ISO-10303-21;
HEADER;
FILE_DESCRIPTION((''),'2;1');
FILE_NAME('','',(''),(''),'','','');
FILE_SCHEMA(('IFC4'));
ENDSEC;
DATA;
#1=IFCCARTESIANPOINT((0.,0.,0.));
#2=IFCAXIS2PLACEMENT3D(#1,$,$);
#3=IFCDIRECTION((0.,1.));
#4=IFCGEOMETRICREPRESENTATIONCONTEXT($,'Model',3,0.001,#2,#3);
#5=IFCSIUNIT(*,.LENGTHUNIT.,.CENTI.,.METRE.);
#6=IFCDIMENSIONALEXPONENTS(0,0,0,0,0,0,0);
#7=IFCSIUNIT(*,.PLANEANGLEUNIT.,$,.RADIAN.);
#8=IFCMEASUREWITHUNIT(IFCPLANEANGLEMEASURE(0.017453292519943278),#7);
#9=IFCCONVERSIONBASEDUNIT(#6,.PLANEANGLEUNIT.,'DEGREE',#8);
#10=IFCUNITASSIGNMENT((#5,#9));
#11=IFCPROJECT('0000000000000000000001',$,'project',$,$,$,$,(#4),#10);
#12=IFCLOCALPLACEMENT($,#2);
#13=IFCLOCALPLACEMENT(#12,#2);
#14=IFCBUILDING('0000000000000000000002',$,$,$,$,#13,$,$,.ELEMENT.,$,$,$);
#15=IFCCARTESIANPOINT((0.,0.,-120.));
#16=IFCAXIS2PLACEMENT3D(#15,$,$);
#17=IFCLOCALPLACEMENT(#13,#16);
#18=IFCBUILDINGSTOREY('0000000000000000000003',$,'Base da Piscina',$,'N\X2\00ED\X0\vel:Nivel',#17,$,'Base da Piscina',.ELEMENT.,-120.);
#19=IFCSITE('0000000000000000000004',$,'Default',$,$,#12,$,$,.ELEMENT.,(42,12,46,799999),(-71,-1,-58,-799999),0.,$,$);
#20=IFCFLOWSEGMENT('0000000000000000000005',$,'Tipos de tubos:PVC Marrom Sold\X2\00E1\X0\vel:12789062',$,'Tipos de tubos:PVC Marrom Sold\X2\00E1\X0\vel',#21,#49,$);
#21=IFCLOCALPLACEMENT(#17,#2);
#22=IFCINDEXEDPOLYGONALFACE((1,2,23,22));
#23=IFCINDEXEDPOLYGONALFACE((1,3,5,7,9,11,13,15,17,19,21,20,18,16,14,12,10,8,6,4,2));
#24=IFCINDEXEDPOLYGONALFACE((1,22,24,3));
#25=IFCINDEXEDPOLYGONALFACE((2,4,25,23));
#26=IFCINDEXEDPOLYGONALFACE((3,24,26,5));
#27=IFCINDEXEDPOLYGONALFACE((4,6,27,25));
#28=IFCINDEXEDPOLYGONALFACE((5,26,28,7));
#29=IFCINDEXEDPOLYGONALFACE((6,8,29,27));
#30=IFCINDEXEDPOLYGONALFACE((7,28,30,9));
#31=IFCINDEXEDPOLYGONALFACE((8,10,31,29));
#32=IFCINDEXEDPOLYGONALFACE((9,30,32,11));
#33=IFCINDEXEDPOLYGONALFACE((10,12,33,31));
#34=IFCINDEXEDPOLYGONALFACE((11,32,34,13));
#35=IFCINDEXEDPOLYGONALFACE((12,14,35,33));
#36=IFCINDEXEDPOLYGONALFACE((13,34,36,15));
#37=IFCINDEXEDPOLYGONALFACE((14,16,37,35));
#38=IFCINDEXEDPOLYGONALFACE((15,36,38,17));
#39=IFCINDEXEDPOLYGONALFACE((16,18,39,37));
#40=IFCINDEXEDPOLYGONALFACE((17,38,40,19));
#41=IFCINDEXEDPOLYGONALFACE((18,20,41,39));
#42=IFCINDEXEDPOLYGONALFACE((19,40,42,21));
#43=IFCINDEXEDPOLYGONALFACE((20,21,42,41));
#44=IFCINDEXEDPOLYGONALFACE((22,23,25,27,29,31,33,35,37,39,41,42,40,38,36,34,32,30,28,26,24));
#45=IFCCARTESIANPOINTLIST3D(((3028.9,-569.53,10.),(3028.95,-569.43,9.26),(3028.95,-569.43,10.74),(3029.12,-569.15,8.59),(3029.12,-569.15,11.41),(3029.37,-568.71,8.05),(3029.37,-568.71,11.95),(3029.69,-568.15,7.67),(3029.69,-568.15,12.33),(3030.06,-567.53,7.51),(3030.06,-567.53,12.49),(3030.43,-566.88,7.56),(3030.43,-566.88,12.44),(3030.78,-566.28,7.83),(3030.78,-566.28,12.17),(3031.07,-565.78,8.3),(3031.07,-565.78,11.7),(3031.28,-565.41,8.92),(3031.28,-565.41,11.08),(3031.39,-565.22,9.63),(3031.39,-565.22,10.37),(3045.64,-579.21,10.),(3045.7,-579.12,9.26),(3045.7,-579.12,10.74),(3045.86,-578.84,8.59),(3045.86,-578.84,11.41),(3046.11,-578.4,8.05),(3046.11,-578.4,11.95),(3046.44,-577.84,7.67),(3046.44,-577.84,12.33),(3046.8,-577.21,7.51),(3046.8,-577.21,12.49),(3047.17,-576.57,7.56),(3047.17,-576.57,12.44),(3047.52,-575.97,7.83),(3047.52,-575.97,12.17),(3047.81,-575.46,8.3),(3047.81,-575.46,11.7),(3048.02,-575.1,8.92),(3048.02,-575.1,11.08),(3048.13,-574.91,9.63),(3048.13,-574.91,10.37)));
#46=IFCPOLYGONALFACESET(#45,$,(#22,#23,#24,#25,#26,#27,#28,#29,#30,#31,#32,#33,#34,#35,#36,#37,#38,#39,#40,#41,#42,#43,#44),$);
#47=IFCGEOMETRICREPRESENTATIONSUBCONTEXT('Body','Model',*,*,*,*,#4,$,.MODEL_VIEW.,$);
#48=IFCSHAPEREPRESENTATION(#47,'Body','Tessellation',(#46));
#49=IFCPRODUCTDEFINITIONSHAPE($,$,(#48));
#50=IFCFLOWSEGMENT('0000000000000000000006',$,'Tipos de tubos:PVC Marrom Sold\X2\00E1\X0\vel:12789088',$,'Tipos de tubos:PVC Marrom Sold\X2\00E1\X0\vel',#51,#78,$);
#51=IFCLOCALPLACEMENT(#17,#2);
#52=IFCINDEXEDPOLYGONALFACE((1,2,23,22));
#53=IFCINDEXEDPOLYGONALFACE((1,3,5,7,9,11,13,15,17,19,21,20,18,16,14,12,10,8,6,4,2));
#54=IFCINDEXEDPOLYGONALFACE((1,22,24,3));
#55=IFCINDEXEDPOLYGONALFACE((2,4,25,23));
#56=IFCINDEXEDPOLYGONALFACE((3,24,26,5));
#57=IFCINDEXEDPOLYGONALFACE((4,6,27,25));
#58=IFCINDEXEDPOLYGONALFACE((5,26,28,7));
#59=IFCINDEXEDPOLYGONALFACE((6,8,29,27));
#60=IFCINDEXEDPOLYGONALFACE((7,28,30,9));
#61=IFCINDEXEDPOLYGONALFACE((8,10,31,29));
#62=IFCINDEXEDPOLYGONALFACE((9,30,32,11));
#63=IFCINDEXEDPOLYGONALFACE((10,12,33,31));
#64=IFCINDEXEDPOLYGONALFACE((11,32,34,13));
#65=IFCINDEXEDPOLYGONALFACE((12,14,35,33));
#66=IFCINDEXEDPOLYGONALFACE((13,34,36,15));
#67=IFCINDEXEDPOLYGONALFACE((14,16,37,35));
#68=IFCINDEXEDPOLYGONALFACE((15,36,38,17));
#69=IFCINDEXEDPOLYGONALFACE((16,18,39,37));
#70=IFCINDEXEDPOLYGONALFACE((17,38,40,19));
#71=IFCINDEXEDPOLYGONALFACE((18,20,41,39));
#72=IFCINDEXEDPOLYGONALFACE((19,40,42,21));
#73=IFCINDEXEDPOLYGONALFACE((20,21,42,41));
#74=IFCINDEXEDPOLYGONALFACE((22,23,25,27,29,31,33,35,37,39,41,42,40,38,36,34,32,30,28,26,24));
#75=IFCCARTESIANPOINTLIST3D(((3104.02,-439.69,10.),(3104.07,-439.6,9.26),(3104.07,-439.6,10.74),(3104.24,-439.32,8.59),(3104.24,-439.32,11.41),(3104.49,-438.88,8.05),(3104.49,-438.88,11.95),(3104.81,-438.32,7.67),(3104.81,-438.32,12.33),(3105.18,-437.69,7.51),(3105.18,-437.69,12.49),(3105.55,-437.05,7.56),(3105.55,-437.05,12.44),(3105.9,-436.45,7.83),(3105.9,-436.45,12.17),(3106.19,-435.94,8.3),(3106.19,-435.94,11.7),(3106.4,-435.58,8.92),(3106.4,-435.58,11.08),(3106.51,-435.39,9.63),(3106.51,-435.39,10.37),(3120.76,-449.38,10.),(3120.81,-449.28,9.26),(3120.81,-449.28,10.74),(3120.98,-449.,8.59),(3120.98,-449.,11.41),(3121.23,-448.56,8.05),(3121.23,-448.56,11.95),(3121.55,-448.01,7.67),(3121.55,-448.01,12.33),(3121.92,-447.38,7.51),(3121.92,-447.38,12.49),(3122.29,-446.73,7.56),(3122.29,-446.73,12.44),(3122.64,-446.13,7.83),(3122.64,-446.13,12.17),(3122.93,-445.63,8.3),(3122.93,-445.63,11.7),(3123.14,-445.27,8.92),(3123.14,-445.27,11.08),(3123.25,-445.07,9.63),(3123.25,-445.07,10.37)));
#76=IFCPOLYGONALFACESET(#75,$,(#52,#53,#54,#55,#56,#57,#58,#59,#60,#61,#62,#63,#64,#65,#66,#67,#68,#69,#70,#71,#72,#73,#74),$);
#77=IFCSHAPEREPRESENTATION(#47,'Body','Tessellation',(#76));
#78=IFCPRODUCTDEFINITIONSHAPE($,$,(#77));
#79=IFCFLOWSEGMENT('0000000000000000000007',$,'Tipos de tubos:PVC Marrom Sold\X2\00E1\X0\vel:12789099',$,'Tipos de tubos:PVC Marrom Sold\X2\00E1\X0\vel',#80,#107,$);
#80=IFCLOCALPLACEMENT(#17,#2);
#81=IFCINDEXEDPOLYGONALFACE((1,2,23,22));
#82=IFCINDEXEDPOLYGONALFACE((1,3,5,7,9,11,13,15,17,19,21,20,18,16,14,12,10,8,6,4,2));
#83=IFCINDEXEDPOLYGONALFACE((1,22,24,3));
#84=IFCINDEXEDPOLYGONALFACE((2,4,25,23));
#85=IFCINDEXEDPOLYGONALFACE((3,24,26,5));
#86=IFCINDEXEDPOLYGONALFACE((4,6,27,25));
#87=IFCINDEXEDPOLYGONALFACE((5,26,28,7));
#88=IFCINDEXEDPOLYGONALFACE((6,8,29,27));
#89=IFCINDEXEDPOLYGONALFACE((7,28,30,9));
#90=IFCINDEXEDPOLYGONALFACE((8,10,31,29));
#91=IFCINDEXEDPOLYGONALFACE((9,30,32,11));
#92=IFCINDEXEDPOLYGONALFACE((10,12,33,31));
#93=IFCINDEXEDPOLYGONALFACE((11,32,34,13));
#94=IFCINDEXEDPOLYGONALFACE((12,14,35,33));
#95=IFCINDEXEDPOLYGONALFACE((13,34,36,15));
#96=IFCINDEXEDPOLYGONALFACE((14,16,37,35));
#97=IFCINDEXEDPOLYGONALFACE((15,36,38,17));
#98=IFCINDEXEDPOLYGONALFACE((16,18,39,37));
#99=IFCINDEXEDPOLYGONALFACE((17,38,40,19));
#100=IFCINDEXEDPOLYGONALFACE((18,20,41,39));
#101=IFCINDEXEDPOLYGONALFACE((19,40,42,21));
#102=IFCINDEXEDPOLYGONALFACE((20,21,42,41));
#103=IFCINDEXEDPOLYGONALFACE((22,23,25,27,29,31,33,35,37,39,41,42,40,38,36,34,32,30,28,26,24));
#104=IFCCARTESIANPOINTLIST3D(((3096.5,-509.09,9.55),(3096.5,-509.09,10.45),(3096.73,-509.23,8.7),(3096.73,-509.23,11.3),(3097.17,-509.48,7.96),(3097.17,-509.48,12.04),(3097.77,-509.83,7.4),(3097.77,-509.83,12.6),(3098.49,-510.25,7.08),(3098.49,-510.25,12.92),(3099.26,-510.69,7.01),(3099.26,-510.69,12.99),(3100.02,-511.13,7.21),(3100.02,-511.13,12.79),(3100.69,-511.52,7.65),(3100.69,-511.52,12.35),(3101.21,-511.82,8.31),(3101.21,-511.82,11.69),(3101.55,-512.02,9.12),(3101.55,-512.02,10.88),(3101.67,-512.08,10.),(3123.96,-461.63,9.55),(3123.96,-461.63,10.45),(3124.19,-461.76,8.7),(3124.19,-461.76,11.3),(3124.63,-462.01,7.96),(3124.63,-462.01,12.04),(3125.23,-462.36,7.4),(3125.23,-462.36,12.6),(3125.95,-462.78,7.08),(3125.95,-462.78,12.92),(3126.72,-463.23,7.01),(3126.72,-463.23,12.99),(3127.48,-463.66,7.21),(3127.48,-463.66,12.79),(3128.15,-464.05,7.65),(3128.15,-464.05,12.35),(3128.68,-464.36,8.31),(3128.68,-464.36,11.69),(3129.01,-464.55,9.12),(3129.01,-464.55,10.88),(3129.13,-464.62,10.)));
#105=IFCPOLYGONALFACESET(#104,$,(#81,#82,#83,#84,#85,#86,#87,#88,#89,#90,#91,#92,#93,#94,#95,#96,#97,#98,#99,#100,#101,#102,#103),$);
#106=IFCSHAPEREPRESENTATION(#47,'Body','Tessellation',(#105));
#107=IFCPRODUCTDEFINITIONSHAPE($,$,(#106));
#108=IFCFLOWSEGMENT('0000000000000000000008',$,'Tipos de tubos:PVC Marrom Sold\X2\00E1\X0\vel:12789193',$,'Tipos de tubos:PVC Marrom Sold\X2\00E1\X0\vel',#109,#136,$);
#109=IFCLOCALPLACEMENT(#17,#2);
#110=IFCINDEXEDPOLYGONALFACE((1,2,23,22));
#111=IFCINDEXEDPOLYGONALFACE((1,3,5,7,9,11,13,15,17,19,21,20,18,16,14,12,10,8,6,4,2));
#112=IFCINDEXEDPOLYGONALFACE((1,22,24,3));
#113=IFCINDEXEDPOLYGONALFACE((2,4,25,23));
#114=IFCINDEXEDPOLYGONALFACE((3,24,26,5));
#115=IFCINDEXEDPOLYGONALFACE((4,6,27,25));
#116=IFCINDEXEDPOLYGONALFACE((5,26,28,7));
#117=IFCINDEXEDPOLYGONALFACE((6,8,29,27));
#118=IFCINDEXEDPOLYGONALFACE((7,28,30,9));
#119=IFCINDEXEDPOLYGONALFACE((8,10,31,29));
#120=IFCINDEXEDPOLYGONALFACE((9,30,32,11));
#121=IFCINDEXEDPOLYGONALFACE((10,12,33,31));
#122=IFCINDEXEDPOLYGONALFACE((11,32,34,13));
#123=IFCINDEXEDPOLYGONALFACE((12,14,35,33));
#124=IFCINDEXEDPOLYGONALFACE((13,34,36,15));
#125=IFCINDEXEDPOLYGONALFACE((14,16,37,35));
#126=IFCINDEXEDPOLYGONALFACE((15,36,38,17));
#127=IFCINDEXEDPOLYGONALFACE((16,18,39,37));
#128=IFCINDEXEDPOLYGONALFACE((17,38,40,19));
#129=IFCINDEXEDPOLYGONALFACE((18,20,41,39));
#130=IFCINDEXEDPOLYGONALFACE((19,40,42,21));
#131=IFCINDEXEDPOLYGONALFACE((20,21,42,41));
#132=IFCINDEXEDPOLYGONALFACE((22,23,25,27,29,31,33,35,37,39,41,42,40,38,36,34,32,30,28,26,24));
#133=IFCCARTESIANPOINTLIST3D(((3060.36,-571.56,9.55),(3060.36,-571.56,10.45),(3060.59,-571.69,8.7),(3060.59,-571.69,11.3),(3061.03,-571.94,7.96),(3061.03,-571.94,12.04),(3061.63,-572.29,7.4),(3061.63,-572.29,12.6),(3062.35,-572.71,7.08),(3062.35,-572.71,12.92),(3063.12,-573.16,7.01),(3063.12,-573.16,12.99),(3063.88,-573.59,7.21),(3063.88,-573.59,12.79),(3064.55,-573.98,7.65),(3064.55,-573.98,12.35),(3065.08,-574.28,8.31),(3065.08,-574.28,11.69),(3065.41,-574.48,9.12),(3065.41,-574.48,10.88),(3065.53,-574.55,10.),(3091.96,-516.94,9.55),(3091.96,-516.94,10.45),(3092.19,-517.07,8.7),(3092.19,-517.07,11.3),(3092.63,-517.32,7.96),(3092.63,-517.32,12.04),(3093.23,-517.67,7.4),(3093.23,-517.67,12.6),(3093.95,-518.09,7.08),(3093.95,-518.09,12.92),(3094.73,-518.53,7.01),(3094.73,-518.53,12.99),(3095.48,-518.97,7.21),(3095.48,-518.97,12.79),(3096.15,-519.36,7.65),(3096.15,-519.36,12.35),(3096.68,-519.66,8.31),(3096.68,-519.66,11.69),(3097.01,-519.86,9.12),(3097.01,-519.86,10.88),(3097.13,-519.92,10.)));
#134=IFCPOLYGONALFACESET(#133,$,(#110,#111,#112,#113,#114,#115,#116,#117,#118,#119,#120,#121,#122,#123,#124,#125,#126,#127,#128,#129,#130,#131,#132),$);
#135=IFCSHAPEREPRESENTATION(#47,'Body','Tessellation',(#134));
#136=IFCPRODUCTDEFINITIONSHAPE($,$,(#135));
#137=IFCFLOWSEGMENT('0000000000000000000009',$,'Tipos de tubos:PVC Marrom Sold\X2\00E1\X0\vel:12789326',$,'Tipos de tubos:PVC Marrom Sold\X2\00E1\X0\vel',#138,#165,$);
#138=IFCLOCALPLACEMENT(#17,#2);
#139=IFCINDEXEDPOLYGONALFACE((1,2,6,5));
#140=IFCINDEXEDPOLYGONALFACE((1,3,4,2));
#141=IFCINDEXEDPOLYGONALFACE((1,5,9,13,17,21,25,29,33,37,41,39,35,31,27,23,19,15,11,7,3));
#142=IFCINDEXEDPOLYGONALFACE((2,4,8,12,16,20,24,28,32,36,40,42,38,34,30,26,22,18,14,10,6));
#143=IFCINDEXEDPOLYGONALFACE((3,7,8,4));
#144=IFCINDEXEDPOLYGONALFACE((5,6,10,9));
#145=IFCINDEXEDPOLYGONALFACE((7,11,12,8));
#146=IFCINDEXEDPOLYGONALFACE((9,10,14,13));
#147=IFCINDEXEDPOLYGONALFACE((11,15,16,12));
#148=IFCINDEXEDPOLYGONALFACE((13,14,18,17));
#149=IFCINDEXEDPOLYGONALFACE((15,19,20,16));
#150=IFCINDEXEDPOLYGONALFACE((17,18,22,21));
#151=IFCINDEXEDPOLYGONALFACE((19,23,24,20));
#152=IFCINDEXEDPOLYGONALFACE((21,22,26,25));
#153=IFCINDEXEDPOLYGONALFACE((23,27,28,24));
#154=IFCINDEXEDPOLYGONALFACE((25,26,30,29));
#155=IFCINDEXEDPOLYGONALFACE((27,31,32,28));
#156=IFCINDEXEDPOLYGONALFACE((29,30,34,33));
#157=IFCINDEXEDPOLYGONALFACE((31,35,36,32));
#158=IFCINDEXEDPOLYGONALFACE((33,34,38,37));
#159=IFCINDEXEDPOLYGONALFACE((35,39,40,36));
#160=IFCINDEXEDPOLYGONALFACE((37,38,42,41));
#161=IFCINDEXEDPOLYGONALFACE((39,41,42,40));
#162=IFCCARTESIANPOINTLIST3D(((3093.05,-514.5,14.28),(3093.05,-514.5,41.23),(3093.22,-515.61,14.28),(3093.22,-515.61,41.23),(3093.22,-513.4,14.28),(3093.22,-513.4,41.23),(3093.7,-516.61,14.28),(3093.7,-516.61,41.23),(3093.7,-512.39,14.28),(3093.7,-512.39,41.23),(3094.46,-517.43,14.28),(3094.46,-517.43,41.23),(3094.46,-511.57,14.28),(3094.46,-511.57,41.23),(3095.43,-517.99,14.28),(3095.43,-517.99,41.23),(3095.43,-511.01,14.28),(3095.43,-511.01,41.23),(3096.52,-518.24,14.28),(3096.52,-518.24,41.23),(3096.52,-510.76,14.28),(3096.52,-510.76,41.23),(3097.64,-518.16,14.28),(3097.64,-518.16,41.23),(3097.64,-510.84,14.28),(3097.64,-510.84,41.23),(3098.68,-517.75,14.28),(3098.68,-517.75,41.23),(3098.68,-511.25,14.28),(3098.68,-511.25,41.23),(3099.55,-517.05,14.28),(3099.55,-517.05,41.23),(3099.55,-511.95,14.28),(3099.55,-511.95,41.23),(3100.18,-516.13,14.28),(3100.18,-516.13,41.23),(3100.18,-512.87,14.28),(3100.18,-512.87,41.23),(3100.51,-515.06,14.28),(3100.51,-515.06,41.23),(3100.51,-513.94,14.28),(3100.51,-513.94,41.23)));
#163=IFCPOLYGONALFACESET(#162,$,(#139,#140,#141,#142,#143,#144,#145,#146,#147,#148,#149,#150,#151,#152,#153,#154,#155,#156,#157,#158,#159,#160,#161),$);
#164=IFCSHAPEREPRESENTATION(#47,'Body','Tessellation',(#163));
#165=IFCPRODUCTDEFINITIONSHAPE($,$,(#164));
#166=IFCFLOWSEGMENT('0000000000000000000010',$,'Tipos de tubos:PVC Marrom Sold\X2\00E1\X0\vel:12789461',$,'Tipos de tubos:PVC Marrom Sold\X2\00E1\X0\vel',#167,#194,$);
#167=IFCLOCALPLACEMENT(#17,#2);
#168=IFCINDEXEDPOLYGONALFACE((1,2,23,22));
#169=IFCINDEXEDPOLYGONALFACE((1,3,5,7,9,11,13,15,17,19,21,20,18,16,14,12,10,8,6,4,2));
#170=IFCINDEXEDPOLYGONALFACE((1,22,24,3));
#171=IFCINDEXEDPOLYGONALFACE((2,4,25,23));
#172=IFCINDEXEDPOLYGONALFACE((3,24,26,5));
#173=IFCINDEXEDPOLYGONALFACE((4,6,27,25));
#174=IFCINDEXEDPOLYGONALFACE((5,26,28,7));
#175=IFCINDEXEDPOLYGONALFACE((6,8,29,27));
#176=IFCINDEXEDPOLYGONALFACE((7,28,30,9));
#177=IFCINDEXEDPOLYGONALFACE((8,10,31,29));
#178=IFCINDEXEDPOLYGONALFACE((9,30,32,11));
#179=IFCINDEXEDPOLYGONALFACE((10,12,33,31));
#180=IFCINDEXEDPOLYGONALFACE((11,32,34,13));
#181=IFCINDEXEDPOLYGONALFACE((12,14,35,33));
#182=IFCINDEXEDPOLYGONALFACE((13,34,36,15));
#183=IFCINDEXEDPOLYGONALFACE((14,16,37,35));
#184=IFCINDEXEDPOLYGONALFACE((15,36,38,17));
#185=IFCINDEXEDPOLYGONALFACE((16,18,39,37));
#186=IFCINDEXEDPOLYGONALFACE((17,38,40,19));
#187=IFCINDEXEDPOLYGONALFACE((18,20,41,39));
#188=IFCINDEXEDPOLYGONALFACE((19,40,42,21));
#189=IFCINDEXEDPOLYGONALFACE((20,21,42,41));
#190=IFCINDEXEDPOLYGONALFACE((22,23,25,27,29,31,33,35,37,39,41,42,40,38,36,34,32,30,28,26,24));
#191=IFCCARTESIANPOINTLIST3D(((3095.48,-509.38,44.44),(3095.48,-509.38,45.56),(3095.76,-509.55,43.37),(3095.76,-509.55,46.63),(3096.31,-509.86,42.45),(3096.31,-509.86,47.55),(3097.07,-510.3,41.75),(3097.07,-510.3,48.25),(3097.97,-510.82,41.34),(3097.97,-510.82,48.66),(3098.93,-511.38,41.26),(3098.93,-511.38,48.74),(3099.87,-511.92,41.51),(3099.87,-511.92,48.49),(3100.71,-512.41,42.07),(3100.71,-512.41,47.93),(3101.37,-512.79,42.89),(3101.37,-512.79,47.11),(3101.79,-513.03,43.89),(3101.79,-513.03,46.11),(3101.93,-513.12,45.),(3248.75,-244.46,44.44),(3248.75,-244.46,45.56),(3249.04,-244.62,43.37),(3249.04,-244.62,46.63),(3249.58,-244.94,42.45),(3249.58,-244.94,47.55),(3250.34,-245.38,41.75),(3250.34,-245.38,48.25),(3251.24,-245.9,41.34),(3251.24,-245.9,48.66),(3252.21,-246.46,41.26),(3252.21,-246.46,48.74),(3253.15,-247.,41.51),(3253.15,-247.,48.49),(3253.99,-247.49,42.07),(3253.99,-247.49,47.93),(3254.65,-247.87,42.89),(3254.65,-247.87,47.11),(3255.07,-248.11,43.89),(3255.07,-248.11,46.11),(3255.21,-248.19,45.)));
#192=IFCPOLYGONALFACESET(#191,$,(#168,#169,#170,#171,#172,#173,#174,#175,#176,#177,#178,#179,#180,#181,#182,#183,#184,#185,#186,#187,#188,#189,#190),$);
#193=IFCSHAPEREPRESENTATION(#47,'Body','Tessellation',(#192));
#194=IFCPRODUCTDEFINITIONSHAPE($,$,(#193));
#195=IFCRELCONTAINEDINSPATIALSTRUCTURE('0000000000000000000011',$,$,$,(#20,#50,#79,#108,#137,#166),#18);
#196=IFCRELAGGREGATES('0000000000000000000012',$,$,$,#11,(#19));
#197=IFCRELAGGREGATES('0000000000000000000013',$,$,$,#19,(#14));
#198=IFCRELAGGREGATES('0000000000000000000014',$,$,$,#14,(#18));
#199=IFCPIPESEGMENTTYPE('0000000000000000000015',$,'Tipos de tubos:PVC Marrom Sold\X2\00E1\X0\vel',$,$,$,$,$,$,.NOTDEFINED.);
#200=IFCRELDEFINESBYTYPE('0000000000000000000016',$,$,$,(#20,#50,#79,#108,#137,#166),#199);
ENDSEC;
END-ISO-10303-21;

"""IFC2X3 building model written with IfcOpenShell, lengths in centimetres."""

from ifc_helpers import new_model, entity, si_unit, converted_unit, direction, frame, frame_2d, origin, origin_2d_with_axis, place, context, subcontext, project, spatial, circle, extrude, type_object, element, save


model = new_model("IFC2X3")

# Units and contexts
model_context = context("Model", 3, precision=0.001, world=origin(), true_north=direction((0.0, 1.0)))
body_context = subcontext(model_context, "Body", "Model", "MODEL_VIEW")
ifc_project = project(units=[si_unit("LENGTHUNIT", "METRE", prefix="CENTI"), converted_unit("PLANEANGLEUNIT", "DEGREE", entity("IfcPlaneAngleMeasure", 0.017453292519943278), si_unit("PLANEANGLEUNIT", "RADIAN"), dimensions=[0, 0, 0, 0, 0, 0, 0])], contexts=[model_context])

# Site, building, storey
site_placement = place(None, origin())
site = spatial("IfcSite", under=ifc_project, at=site_placement, Name="Default", CompositionType="ELEMENT", RefLatitude=(42, 12, 46, 799999), RefLongitude=(-71, -1, -58, -799999), RefElevation=0.0)
building_placement = place(site_placement, origin())
building = spatial("IfcBuilding", under=site, at=building_placement, CompositionType="ELEMENT")
storey_placement = place(building_placement, frame((0.0, 0.0, -120.0)))
storey = spatial("IfcBuildingStorey", under=building, at=storey_placement, Name="Base da Piscina", ObjectType="Nível:Nivel", LongName="Base da Piscina", CompositionType="ELEMENT", Elevation=-120.0)

# Flow segments
pipe_segment_type = type_object("IfcPipeSegmentType", Name="Tipos de tubos:PVC Marrom Soldável", PredefinedType="NOTDEFINED")
flow_segment_1_placement = place(storey_placement, origin())
element("IfcFlowSegment", 1, at=flow_segment_1_placement, inside=storey, type_object=pipe_segment_type, Name="Tipos de tubos:PVC Marrom Soldável:12789062", ObjectType="Tipos de tubos:PVC Marrom Soldável", context=body_context, shape_type="SweptSolid", body=[
    extrude(circle(Radius=2.5, at=frame_2d((0.0, 0.0), x_axis=(1.0, 0.0))), frame((3046.89, -577.05, 10.0), z_axis=(-0.865569, 0.50079, 0.0), x_axis=(-0.50079, -0.865569, 0.0)), (0.0, 0.0, 1.0), 19.34),
])
flow_segment_2_placement = place(storey_placement, origin())
element("IfcFlowSegment", 2, at=flow_segment_2_placement, inside=storey, type_object=pipe_segment_type, Name="Tipos de tubos:PVC Marrom Soldável:12789088", ObjectType="Tipos de tubos:PVC Marrom Soldável", context=body_context, shape_type="SweptSolid", body=[
    extrude(circle(Radius=2.5, at=frame_2d((0.0, 0.0), x_axis=(1.0, 0.0))), frame((3105.27, -437.53, 10.0), z_axis=(0.865569, -0.50079, 0.0), x_axis=(-0.50079, -0.865569, 0.0)), (0.0, 0.0, 1.0), 19.34),
])
flow_segment_3_placement = place(storey_placement, origin())
element("IfcFlowSegment", 3, at=flow_segment_3_placement, inside=storey, type_object=pipe_segment_type, Name="Tipos de tubos:PVC Marrom Soldável:12789099", ObjectType="Tipos de tubos:PVC Marrom Soldável", context=body_context, shape_type="SweptSolid", body=[
    extrude(circle(Radius=3.0, at=origin_2d_with_axis()), frame((3099.07, -510.58, 10.0), z_axis=(0.50079, 0.865569, 0.0), x_axis=(0.865569, -0.50079, 0.0)), (0.0, 0.0, 1.0), 54.84),
])
flow_segment_4_placement = place(storey_placement, origin())
element("IfcFlowSegment", 4, at=flow_segment_4_placement, inside=storey, type_object=pipe_segment_type, Name="Tipos de tubos:PVC Marrom Soldável:12789193", ObjectType="Tipos de tubos:PVC Marrom Soldável", context=body_context, shape_type="SweptSolid", body=[
    extrude(circle(Radius=3.0, at=origin_2d_with_axis()), frame((3062.93, -573.04, 10.0), z_axis=(0.50079, 0.865569, 0.0), x_axis=(0.865569, -0.50079, 0.0)), (0.0, 0.0, 1.0), 63.1),
])
flow_segment_5_placement = place(storey_placement, origin())
element("IfcFlowSegment", 5, at=flow_segment_5_placement, inside=storey, type_object=pipe_segment_type, Name="Tipos de tubos:PVC Marrom Soldável:12789326", ObjectType="Tipos de tubos:PVC Marrom Soldável", context=body_context, shape_type="SweptSolid", body=[
    extrude(circle(Radius=3.75, at=origin_2d_with_axis()), frame((3096.8, -514.5, 14.28), z_axis=(0.0, 0.0, 1.0), x_axis=(-1.0, 0.0, 0.0)), (0.0, 0.0, 1.0), 26.95),
])
flow_segment_6_placement = place(storey_placement, origin())
element("IfcFlowSegment", 6, at=flow_segment_6_placement, inside=storey, type_object=pipe_segment_type, Name="Tipos de tubos:PVC Marrom Soldável:12789461", ObjectType="Tipos de tubos:PVC Marrom Soldável", context=body_context, shape_type="SweptSolid", body=[
    extrude(circle(Radius=3.75, at=origin_2d_with_axis()), frame((3098.69, -511.24, 45.0), z_axis=(0.50079, 0.865569, 0.0), x_axis=(0.865569, -0.50079, 0.0)), (0.0, 0.0, 1.0), 306.07),
])

save(model, "model.ifc")
